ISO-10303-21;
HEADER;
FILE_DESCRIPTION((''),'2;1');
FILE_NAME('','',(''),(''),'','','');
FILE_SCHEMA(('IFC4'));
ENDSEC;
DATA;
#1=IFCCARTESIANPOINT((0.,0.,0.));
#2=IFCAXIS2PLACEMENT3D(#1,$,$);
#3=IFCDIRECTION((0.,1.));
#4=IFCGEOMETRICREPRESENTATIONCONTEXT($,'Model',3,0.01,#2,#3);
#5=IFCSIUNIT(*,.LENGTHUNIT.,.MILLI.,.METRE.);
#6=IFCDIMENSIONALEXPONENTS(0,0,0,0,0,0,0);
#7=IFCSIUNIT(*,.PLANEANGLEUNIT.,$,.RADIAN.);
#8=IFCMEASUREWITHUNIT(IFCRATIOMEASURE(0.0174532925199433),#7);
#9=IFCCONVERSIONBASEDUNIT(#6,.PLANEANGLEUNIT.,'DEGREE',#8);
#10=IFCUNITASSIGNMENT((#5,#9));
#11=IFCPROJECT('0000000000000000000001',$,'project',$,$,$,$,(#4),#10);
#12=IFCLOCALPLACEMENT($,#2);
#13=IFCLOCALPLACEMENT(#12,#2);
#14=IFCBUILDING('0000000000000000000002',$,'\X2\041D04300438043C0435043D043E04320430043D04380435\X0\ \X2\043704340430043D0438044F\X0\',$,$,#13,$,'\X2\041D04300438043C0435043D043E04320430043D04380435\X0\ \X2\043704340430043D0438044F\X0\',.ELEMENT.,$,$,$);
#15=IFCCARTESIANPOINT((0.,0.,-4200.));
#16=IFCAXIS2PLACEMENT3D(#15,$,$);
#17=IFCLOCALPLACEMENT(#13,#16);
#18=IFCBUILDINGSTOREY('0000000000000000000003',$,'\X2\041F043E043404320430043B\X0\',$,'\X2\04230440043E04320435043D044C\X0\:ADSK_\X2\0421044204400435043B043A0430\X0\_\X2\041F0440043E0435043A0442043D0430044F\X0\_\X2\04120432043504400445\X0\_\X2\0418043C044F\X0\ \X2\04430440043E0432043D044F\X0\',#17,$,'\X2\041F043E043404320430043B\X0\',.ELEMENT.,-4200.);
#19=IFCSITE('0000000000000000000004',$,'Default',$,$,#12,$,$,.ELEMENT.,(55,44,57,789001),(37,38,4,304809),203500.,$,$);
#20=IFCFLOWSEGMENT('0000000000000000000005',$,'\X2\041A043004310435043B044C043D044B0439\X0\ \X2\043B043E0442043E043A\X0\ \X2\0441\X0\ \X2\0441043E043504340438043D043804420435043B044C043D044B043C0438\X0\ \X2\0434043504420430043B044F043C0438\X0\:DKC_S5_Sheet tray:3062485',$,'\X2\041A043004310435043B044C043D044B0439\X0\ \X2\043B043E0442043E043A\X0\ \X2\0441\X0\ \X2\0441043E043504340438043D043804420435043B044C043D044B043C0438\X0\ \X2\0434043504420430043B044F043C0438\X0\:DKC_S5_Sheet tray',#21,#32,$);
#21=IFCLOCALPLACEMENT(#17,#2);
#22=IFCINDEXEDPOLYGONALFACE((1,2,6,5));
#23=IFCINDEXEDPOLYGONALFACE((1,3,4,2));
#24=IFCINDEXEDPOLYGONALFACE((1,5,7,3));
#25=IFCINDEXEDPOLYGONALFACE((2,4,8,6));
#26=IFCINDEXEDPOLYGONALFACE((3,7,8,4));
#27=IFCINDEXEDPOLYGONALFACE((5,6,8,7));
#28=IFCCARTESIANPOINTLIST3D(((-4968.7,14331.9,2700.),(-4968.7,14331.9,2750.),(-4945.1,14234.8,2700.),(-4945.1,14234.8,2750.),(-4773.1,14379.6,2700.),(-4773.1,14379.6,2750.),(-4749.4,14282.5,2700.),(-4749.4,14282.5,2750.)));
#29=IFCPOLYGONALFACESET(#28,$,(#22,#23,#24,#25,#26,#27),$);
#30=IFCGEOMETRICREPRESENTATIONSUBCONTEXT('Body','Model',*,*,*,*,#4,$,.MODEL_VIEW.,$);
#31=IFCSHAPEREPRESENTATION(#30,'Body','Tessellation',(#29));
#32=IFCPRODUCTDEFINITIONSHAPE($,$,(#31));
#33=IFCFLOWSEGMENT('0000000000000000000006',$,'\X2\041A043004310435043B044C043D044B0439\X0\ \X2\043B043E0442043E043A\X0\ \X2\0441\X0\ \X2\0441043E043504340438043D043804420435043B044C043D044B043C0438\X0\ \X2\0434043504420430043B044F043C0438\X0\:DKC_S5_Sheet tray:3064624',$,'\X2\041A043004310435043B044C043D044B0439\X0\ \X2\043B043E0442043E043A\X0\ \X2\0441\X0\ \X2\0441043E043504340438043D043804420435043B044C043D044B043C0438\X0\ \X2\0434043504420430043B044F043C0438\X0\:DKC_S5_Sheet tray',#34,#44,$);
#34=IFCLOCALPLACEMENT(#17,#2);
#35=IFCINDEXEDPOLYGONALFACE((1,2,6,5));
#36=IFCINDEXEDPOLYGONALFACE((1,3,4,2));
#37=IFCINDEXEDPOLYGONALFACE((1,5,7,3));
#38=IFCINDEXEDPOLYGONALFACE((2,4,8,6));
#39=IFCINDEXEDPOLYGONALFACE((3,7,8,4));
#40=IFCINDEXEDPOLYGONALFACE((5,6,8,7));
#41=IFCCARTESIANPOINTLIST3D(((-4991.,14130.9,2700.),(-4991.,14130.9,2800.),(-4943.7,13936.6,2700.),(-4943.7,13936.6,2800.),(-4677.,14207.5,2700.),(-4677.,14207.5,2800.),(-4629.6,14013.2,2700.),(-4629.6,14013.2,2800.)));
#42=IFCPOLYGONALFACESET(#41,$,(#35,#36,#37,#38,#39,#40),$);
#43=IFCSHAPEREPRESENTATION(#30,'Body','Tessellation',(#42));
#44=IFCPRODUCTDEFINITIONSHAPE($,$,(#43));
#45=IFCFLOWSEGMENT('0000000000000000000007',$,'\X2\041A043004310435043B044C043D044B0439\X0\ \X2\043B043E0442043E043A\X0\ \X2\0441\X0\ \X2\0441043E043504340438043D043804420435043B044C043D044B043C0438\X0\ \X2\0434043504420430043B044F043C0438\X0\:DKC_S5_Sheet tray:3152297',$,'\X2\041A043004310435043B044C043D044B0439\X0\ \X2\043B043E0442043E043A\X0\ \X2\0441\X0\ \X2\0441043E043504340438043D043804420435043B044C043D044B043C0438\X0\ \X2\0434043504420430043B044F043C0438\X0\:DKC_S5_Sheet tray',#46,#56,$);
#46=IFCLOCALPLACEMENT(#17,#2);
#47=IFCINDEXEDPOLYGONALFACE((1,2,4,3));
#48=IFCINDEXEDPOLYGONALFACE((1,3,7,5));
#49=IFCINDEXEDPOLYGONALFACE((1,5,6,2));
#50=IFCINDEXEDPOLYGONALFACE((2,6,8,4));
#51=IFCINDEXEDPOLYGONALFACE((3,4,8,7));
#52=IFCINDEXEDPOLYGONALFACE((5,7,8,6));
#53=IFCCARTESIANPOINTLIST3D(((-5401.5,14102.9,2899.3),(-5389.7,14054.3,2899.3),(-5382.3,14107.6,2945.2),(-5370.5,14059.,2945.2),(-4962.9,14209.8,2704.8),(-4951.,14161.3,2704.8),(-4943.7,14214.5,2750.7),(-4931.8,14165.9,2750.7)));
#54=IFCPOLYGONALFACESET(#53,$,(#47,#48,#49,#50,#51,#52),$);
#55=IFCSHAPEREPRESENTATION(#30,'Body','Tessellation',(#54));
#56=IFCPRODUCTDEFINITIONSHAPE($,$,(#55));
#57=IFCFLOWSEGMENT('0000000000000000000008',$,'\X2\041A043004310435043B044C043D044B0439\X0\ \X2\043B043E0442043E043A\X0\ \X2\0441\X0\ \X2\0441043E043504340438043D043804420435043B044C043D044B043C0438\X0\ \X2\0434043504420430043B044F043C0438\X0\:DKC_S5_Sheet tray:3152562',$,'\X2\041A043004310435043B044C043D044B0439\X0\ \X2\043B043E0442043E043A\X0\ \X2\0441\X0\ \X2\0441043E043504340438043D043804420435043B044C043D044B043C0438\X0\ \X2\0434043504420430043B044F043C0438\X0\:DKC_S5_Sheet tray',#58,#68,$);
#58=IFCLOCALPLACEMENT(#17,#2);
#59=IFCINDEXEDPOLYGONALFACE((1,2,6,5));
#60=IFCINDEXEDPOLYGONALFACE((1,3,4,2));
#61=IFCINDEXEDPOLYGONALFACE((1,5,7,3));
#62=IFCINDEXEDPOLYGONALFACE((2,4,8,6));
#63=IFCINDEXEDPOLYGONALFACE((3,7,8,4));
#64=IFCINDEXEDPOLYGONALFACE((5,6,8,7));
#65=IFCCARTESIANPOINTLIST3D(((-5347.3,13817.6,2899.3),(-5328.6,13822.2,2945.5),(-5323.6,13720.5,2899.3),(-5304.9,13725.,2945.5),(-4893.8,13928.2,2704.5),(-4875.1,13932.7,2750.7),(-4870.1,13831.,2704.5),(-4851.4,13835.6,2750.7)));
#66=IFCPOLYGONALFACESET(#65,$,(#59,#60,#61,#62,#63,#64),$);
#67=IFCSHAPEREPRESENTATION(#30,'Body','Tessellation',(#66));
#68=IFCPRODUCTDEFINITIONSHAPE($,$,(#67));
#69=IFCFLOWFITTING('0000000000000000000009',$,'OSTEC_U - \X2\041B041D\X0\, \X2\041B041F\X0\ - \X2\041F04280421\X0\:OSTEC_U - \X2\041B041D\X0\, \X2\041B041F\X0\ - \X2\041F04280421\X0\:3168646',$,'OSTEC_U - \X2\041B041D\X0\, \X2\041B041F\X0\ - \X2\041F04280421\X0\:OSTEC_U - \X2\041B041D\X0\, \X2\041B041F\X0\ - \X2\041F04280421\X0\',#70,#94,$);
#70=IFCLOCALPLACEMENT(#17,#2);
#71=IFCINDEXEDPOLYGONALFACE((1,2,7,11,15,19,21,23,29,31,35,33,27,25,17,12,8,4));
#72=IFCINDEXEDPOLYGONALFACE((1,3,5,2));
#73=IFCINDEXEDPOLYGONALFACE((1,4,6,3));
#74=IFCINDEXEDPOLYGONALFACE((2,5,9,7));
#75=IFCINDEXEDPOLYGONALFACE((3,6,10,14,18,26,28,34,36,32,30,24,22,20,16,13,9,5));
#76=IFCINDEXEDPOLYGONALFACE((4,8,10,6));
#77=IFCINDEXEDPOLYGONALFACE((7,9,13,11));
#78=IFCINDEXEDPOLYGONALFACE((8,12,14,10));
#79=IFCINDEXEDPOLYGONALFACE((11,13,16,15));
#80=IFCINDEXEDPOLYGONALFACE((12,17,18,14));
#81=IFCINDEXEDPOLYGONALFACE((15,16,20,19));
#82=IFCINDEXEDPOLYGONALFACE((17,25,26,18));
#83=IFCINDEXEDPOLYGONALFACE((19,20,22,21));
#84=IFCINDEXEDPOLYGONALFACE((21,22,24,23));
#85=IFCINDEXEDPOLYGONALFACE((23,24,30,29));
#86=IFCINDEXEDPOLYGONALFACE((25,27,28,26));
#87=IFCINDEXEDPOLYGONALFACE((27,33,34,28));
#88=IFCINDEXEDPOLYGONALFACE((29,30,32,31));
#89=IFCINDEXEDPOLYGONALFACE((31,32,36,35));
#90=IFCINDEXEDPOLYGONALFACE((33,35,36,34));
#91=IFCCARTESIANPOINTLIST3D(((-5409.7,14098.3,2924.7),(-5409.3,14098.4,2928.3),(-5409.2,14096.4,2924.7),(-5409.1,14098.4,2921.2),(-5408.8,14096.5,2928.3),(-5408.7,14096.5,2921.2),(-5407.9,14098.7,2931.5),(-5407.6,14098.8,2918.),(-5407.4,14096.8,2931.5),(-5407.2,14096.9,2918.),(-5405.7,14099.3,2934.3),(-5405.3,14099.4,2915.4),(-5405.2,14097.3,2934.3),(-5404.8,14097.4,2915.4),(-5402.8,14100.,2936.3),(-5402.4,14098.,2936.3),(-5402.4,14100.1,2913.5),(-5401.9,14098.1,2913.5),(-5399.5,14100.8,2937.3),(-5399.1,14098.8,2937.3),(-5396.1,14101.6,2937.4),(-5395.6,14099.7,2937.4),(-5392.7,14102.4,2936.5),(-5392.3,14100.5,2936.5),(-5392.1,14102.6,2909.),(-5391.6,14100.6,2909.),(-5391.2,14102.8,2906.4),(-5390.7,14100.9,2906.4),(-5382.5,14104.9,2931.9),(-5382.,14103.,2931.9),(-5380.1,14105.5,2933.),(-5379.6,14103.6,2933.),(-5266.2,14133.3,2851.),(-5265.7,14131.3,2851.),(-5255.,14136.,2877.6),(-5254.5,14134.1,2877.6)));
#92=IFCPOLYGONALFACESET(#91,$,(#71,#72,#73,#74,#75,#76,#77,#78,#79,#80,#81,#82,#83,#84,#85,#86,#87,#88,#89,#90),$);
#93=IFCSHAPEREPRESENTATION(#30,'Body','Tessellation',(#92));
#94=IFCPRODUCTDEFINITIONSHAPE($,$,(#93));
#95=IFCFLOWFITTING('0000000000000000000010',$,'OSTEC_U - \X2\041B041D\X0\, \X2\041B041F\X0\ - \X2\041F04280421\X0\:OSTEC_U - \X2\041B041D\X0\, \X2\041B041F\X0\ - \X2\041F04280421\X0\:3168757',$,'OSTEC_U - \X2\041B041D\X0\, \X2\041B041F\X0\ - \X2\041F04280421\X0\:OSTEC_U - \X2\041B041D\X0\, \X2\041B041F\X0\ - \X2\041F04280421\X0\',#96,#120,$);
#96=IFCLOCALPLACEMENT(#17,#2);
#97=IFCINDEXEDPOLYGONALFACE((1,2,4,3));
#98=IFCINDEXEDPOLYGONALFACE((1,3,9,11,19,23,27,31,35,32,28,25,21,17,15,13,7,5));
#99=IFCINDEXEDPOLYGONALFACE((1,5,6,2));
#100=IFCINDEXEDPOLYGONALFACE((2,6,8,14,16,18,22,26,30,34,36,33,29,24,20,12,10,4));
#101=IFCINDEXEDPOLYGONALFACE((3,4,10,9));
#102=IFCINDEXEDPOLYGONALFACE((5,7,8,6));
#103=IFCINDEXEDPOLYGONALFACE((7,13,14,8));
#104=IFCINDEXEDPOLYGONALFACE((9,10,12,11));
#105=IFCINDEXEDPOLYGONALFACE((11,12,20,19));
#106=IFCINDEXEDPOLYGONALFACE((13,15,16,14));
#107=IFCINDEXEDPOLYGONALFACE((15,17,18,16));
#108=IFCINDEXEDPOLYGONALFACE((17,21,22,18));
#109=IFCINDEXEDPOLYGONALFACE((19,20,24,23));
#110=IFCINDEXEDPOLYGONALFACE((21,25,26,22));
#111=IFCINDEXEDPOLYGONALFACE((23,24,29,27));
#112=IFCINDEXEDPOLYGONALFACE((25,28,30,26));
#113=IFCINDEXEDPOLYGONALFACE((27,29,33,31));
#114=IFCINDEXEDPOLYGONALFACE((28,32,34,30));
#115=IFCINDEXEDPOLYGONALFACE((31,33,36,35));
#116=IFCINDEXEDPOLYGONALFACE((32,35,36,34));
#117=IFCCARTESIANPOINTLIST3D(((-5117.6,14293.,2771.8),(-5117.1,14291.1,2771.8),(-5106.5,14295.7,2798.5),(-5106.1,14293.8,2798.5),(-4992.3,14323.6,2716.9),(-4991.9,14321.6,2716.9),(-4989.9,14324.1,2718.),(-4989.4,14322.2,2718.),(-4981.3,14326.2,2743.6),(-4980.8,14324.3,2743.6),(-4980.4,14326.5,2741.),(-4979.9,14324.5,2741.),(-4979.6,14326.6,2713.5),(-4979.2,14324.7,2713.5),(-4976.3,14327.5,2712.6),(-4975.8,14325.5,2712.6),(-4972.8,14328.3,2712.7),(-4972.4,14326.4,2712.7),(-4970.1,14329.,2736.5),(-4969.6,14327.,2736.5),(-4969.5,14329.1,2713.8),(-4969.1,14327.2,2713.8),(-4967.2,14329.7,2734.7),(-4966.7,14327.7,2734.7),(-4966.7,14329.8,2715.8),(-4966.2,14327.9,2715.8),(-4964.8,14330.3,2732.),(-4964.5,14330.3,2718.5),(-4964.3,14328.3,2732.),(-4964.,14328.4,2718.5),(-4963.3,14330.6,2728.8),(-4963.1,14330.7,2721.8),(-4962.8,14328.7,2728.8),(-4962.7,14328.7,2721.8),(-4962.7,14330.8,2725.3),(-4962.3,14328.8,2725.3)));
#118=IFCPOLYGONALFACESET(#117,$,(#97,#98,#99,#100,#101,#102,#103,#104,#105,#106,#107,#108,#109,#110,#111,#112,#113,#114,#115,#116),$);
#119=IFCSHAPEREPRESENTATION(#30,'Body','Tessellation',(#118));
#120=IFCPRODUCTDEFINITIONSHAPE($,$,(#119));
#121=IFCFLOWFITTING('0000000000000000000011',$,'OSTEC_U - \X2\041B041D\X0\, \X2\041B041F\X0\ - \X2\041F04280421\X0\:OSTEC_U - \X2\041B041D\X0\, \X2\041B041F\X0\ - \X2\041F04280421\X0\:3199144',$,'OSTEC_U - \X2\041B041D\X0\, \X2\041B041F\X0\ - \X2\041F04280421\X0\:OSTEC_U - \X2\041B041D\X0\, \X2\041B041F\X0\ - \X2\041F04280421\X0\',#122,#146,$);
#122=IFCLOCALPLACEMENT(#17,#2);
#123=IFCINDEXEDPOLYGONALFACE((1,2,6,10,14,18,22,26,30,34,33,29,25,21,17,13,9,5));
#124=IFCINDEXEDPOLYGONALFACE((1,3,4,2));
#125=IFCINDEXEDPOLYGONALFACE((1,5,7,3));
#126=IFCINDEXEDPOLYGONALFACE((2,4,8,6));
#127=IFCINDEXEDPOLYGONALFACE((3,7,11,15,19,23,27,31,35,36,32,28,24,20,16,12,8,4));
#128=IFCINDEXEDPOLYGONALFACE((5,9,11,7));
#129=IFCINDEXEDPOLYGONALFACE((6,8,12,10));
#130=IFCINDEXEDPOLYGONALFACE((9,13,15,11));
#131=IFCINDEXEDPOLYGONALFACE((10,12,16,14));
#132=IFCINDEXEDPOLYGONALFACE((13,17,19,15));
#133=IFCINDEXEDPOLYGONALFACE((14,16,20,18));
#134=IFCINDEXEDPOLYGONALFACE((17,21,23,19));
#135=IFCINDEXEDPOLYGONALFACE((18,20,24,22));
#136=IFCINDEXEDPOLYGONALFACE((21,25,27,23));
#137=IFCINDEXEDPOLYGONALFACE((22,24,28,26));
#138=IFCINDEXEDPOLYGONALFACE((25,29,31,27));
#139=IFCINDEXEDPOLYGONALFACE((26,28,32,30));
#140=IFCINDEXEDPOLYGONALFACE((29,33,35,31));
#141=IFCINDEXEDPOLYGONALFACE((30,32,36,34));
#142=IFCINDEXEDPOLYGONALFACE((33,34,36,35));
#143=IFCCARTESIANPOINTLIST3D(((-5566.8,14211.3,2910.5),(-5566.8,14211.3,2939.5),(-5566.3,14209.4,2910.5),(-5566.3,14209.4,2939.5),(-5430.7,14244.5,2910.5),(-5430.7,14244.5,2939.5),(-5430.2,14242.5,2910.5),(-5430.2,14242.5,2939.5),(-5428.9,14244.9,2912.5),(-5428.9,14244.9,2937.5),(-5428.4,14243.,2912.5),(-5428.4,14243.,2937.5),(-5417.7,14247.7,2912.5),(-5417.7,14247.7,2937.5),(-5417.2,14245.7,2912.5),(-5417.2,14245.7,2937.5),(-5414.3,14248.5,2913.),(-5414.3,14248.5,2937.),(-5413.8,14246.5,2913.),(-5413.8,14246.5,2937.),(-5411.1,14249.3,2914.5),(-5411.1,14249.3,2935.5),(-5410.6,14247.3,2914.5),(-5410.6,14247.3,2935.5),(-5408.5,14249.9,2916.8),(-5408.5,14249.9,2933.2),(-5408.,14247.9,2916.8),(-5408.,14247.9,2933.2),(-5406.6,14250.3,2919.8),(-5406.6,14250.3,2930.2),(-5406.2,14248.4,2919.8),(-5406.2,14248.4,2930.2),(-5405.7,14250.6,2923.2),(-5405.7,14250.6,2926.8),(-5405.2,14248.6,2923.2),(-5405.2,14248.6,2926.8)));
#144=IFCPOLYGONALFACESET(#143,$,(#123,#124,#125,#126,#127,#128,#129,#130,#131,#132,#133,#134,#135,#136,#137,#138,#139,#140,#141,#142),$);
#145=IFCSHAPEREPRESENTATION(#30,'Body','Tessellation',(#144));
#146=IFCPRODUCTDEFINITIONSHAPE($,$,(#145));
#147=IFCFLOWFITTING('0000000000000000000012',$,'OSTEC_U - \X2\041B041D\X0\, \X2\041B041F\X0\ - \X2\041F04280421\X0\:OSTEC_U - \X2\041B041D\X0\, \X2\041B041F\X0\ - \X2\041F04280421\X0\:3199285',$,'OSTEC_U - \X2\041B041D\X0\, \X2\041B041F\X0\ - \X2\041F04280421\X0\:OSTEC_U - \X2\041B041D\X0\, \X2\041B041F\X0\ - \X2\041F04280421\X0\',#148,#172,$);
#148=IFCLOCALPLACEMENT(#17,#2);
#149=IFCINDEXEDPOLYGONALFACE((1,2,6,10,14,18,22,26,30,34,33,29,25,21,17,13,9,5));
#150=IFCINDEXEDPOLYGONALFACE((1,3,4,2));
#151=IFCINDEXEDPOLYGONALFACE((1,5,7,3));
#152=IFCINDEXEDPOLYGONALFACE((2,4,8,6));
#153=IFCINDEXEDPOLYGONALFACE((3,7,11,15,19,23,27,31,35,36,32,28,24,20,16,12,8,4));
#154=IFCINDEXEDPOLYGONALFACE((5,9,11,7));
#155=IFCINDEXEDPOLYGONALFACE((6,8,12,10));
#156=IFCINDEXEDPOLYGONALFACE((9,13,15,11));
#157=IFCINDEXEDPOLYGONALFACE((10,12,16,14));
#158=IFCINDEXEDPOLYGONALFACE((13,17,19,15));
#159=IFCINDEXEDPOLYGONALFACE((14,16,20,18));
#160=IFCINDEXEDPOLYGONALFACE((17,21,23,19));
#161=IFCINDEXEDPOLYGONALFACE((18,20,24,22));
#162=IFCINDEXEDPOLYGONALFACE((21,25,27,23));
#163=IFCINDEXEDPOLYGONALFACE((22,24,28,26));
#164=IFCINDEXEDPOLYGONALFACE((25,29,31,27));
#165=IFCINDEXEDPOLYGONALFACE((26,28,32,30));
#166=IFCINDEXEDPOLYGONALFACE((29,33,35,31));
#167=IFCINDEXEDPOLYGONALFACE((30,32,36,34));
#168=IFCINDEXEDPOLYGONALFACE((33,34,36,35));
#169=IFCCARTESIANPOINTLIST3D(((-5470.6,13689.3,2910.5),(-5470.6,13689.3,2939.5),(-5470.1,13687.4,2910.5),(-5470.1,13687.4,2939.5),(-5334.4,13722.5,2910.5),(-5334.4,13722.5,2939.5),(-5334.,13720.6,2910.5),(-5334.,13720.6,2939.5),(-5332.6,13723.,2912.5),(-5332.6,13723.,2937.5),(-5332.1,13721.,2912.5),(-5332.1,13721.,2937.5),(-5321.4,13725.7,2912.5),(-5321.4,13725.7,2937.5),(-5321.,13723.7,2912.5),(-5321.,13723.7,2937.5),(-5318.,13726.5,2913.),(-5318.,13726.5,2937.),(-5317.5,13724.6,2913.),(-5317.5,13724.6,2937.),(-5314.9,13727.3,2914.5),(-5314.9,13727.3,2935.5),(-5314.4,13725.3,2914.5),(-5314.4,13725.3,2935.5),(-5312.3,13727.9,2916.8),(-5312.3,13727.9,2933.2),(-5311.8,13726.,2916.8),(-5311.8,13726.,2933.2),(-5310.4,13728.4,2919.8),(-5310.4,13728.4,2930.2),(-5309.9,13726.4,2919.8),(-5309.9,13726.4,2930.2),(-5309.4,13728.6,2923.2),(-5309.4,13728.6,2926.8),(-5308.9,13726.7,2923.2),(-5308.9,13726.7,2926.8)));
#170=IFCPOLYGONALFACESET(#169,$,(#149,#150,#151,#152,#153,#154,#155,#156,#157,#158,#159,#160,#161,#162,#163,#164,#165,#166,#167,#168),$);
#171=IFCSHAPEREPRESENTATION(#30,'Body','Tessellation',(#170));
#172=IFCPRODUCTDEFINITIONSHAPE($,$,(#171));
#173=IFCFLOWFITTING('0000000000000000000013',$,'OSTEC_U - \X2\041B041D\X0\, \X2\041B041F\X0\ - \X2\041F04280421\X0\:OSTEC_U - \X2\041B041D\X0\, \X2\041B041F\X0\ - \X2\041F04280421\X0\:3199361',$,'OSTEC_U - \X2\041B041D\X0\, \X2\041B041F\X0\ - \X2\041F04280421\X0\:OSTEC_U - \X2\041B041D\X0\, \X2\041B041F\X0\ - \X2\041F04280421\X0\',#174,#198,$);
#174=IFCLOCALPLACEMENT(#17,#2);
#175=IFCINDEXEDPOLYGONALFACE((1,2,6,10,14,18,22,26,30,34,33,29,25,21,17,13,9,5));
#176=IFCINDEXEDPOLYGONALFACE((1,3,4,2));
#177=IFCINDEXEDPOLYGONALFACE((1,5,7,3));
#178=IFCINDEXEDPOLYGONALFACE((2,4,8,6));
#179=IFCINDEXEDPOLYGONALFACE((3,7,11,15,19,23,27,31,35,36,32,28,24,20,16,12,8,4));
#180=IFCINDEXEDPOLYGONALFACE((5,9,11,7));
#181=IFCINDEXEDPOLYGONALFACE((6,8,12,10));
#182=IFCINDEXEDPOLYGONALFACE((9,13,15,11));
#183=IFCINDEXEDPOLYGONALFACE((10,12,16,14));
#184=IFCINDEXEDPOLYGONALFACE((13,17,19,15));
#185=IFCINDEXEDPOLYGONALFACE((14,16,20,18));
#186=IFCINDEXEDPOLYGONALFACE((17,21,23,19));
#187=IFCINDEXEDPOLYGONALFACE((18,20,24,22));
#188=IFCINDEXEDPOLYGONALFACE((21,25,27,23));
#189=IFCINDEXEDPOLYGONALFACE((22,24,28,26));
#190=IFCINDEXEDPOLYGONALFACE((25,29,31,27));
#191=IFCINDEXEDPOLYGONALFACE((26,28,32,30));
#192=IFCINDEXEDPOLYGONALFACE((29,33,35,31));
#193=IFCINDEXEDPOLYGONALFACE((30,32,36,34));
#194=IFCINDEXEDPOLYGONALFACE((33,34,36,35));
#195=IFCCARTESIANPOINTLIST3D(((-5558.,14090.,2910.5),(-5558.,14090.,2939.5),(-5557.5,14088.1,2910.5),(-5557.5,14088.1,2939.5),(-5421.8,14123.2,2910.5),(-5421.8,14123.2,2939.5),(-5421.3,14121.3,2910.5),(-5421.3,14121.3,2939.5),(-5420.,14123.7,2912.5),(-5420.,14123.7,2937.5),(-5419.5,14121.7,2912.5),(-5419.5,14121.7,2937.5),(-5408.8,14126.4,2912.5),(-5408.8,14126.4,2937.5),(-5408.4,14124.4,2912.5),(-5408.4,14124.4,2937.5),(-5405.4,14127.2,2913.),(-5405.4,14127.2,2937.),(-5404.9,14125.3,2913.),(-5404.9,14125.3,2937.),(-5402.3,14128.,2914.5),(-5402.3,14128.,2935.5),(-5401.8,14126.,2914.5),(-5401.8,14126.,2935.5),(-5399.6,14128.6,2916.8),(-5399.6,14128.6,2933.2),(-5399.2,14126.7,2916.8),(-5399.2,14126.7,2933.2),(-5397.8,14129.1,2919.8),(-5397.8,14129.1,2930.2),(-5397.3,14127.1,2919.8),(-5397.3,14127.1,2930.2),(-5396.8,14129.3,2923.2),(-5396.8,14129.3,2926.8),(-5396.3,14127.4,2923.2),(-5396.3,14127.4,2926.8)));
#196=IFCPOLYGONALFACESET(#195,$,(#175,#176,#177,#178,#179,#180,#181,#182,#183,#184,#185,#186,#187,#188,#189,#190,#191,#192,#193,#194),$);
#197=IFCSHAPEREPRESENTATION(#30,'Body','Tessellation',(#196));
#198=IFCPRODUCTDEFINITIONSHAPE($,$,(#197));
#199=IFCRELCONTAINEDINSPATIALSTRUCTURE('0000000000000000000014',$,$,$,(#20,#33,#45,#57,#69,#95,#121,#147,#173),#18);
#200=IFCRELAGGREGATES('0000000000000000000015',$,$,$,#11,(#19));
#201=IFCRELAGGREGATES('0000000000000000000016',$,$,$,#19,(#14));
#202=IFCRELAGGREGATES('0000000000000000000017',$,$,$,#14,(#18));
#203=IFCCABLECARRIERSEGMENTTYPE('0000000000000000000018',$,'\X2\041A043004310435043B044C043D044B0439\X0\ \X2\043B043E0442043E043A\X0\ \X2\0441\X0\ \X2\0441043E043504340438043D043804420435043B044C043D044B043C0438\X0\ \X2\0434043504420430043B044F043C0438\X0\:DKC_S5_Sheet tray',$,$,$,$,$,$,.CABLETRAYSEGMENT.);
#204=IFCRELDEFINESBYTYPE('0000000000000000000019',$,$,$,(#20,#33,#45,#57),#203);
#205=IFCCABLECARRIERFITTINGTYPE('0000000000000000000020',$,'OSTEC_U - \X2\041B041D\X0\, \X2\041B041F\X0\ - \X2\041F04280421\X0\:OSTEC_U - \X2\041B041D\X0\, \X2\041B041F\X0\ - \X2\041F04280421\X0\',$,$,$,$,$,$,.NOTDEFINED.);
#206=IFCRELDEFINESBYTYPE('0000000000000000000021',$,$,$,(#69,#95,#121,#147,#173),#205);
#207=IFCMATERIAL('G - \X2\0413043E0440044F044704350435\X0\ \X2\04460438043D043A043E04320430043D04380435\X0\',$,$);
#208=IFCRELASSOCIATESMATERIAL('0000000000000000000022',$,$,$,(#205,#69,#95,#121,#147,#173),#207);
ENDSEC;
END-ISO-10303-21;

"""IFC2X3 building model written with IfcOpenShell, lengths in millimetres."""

from ifc_helpers import new_model, entity, si_unit, converted_unit, direction, frame, frame_2d, origin, place, context, subcontext, project, spatial, polyline, circle_curve, parameter, trimmed, segment, composite_curve, rectangle, outline, extrude, source, transform, mapped, material, type_object, type_shapes, element, save


model = new_model("IFC2X3")

# Units and contexts
model_context = context("Model", 3, precision=0.01, world=origin(), true_north=direction((0.0, 1.0)))
body_context = subcontext(model_context, "Body", "Model", "MODEL_VIEW")
ifc_project = project(units=[si_unit("LENGTHUNIT", "METRE", prefix="MILLI"), converted_unit("PLANEANGLEUNIT", "DEGREE", entity("IfcRatioMeasure", 0.0174532925199433), si_unit("PLANEANGLEUNIT", "RADIAN"), dimensions=[0, 0, 0, 0, 0, 0, 0])], contexts=[model_context])

# Site, building, storey
site_placement = place(None, frame((0.0, 0.0, 0.0)))
site = spatial("IfcSite", under=ifc_project, at=site_placement, Name="Default", CompositionType="ELEMENT", RefLatitude=(55, 44, 57, 789001), RefLongitude=(37, 38, 4, 304809), RefElevation=203500.0)
building_placement = place(site_placement, origin())
building = spatial("IfcBuilding", under=site, at=building_placement, Name="Наименование здания", LongName="Наименование здания", CompositionType="ELEMENT")
storey_placement = place(building_placement, frame((0.0, 0.0, -4200.0)))
storey = spatial("IfcBuildingStorey", under=building, at=storey_placement, Name="Подвал", ObjectType="Уровень:ADSK_Стрелка_Проектная_Вверх_Имя уровня", LongName="Подвал", CompositionType="ELEMENT", Elevation=-4200.0)

# Flow segments
cable_carrier_segment_type = type_object("IfcCableCarrierSegmentType", Name="Кабельный лоток с соединительными деталями:DKC_S5_Sheet tray", PredefinedType="CABLETRAYSEGMENT")
flow_segment_1_placement = place(storey_placement, frame((-4968.7, 14234.8, 2700.0)))
element("IfcFlowSegment", 1, at=flow_segment_1_placement, inside=storey, type_object=cable_carrier_segment_type, Name="Кабельный лоток с соединительными деталями:DKC_S5_Sheet tray:3062485", ObjectType="Кабельный лоток с соединительными деталями:DKC_S5_Sheet tray", context=body_context, shape_type="SweptSolid", body=[
    extrude(rectangle(XDim=201.4, YDim=100.0, at=frame_2d((0.0, 0.0), x_axis=(1.0, 0.0))), frame((109.7, 72.4, 0.0), z_axis=(0.0, 0.0, 1.0), x_axis=(-0.971553, -0.236821, 0.0)), (0.0, 0.0, 1.0), 50.0),
])
flow_segment_2_placement = place(storey_placement, frame((-4991.0, 13936.6, 2700.0)))
element("IfcFlowSegment", 2, at=flow_segment_2_placement, inside=storey, type_object=cable_carrier_segment_type, Name="Кабельный лоток с соединительными деталями:DKC_S5_Sheet tray:3064624", ObjectType="Кабельный лоток с соединительными деталями:DKC_S5_Sheet tray", context=body_context, shape_type="SweptSolid", body=[
    extrude(rectangle(XDim=323.3, YDim=200.0, at=frame_2d((0.0, 0.0), x_axis=(1.0, 0.0))), frame((180.7, 135.4, 0.0), z_axis=(0.0, 0.0, 1.0), x_axis=(-0.971553, -0.236821, 0.0)), (0.0, 0.0, 1.0), 100.0),
])
flow_segment_3_placement = place(storey_placement, frame((-5401.5, 14054.3, 2704.8)))
element("IfcFlowSegment", 3, at=flow_segment_3_placement, inside=storey, type_object=cable_carrier_segment_type, Name="Кабельный лоток с соединительными деталями:DKC_S5_Sheet tray:3152297", ObjectType="Кабельный лоток с соединительными деталями:DKC_S5_Sheet tray", context=body_context, shape_type="SweptSolid", body=[
    extrude(rectangle(XDim=50.0, YDim=50.0, at=frame_2d((0.0, 0.0), x_axis=(1.0, 0.0))), frame((15.5, 26.6, 217.4), z_axis=(0.892295, 0.217501, -0.395604), x_axis=(0.38435, 0.093687, 0.918421)), (0.0, 0.0, 1.0), 491.6),
])
flow_segment_4_placement = place(storey_placement, frame((-5347.3, 13720.5, 2704.5)))
element("IfcFlowSegment", 4, at=flow_segment_4_placement, inside=storey, type_object=cable_carrier_segment_type, Name="Кабельный лоток с соединительными деталями:DKC_S5_Sheet tray:3152562", ObjectType="Кабельный лоток с соединительными деталями:DKC_S5_Sheet tray", context=body_context, shape_type="SweptSolid", body=[
    extrude(rectangle(XDim=50.0, YDim=100.0, at=frame_2d((0.0, 0.0), x_axis=(1.0, 0.0))), frame((21.2, 50.9, 217.8), z_axis=(0.896628, 0.218557, -0.385085), x_axis=(0.37413, 0.091196, 0.922881)), (0.0, 0.0, 1.0), 505.8),
])

# Flow fittings
ifc_material = material(Name="G - Горячее цинкование")
cable_carrier_fitting_type_1 = type_object("IfcCableCarrierFittingType", Name="OSTEC_U - ЛН, ЛП - ПШС:OSTEC_U - ЛН, ЛП - ПШС", PredefinedType="NOTDEFINED", material=ifc_material)
shared_shape_1 = source(origin(), body_context, "Body", "SweptSolid", [
    extrude(outline(composite_curve([segment(trimmed(circle_curve(frame_2d((-44.6, 0.0), x_axis=(1.0, 0.0)), 12.5), [parameter(90.0)], [parameter(270.0)], True, "PARAMETER"), True, "CONTINUOUS"), segment(polyline([(-44.6, -12.5), (-33.1, -12.5)]), True, "CONTINUOUS"), segment(polyline([(-33.1, -12.5), (-31.2, -14.5)]), True, "CONTINUOUS"), segment(polyline([(-31.2, -14.5), (108.9, -14.5)]), True, "CONTINUOUS"), segment(polyline([(108.9, -14.5), (108.9, 14.5)]), True, "CONTINUOUS"), segment(polyline([(108.9, 14.5), (-31.2, 14.5)]), True, "CONTINUOUS"), segment(polyline([(-31.2, 14.5), (-33.1, 12.5)]), True, "CONTINUOUS"), segment(polyline([(-33.1, 12.5), (-44.6, 12.5)]), True, "CONTINUOUS")], self_intersect=False)), frame((44.6, 0.0, 0.0), z_axis=(0.0, 0.0, -1.0), x_axis=(1.0, 0.0, 0.0)), (0.0, 0.0, -1.0), 2.0),
])
type_shapes(cable_carrier_fitting_type_1, [shared_shape_1])
for number, where, z_axis, x_axis, name in (
    (5, (-5397.1, 14099.3, 2925.0), (-0.236821, 0.971553, 0.0), (0.892295, 0.217501, -0.395604), "OSTEC_U - ЛН, ЛП - ПШС:OSTEC_U - ЛН, ЛП - ПШС:3168646"),
    (6, (-4974.4, 14325.9, 2725.0), (-0.236821, 0.971553, 0.0), (-0.893779, -0.217863, 0.39204), "OSTEC_U - ЛН, ЛП - ПШС:OSTEC_U - ЛН, ЛП - ПШС:3168757"),
    (7, (-5417.7, 14247.7, 2925.0), (0.236821, -0.971553, 0.0), (-0.971553, -0.236821, 0.0), "OSTEC_U - ЛН, ЛП - ПШС:OSTEC_U - ЛН, ЛП - ПШС:3199144"),
    (8, (-5321.4, 13725.7, 2925.0), (0.236821, -0.971553, 0.0), (-0.971553, -0.236821, 0.0), "OSTEC_U - ЛН, ЛП - ПШС:OSTEC_U - ЛН, ЛП - ПШС:3199285"),
    (9, (-5408.8, 14126.4, 2925.0), (0.236821, -0.971553, 0.0), (-0.971553, -0.236821, 0.0), "OSTEC_U - ЛН, ЛП - ПШС:OSTEC_U - ЛН, ЛП - ПШС:3199361"),
):
    element("IfcFlowFitting", number, at=place(storey_placement, frame(where, z_axis=z_axis, x_axis=x_axis)), inside=storey, type_object=cable_carrier_fitting_type_1, material=ifc_material, Name=name, ObjectType="OSTEC_U - ЛН, ЛП - ПШС:OSTEC_U - ЛН, ЛП - ПШС", context=body_context, shape_type="MappedRepresentation", body=[
        mapped(shared_shape_1, transform((0.0, 0.0, 0.0), scale=1.0)),
    ])

save(model, "model.ifc")
